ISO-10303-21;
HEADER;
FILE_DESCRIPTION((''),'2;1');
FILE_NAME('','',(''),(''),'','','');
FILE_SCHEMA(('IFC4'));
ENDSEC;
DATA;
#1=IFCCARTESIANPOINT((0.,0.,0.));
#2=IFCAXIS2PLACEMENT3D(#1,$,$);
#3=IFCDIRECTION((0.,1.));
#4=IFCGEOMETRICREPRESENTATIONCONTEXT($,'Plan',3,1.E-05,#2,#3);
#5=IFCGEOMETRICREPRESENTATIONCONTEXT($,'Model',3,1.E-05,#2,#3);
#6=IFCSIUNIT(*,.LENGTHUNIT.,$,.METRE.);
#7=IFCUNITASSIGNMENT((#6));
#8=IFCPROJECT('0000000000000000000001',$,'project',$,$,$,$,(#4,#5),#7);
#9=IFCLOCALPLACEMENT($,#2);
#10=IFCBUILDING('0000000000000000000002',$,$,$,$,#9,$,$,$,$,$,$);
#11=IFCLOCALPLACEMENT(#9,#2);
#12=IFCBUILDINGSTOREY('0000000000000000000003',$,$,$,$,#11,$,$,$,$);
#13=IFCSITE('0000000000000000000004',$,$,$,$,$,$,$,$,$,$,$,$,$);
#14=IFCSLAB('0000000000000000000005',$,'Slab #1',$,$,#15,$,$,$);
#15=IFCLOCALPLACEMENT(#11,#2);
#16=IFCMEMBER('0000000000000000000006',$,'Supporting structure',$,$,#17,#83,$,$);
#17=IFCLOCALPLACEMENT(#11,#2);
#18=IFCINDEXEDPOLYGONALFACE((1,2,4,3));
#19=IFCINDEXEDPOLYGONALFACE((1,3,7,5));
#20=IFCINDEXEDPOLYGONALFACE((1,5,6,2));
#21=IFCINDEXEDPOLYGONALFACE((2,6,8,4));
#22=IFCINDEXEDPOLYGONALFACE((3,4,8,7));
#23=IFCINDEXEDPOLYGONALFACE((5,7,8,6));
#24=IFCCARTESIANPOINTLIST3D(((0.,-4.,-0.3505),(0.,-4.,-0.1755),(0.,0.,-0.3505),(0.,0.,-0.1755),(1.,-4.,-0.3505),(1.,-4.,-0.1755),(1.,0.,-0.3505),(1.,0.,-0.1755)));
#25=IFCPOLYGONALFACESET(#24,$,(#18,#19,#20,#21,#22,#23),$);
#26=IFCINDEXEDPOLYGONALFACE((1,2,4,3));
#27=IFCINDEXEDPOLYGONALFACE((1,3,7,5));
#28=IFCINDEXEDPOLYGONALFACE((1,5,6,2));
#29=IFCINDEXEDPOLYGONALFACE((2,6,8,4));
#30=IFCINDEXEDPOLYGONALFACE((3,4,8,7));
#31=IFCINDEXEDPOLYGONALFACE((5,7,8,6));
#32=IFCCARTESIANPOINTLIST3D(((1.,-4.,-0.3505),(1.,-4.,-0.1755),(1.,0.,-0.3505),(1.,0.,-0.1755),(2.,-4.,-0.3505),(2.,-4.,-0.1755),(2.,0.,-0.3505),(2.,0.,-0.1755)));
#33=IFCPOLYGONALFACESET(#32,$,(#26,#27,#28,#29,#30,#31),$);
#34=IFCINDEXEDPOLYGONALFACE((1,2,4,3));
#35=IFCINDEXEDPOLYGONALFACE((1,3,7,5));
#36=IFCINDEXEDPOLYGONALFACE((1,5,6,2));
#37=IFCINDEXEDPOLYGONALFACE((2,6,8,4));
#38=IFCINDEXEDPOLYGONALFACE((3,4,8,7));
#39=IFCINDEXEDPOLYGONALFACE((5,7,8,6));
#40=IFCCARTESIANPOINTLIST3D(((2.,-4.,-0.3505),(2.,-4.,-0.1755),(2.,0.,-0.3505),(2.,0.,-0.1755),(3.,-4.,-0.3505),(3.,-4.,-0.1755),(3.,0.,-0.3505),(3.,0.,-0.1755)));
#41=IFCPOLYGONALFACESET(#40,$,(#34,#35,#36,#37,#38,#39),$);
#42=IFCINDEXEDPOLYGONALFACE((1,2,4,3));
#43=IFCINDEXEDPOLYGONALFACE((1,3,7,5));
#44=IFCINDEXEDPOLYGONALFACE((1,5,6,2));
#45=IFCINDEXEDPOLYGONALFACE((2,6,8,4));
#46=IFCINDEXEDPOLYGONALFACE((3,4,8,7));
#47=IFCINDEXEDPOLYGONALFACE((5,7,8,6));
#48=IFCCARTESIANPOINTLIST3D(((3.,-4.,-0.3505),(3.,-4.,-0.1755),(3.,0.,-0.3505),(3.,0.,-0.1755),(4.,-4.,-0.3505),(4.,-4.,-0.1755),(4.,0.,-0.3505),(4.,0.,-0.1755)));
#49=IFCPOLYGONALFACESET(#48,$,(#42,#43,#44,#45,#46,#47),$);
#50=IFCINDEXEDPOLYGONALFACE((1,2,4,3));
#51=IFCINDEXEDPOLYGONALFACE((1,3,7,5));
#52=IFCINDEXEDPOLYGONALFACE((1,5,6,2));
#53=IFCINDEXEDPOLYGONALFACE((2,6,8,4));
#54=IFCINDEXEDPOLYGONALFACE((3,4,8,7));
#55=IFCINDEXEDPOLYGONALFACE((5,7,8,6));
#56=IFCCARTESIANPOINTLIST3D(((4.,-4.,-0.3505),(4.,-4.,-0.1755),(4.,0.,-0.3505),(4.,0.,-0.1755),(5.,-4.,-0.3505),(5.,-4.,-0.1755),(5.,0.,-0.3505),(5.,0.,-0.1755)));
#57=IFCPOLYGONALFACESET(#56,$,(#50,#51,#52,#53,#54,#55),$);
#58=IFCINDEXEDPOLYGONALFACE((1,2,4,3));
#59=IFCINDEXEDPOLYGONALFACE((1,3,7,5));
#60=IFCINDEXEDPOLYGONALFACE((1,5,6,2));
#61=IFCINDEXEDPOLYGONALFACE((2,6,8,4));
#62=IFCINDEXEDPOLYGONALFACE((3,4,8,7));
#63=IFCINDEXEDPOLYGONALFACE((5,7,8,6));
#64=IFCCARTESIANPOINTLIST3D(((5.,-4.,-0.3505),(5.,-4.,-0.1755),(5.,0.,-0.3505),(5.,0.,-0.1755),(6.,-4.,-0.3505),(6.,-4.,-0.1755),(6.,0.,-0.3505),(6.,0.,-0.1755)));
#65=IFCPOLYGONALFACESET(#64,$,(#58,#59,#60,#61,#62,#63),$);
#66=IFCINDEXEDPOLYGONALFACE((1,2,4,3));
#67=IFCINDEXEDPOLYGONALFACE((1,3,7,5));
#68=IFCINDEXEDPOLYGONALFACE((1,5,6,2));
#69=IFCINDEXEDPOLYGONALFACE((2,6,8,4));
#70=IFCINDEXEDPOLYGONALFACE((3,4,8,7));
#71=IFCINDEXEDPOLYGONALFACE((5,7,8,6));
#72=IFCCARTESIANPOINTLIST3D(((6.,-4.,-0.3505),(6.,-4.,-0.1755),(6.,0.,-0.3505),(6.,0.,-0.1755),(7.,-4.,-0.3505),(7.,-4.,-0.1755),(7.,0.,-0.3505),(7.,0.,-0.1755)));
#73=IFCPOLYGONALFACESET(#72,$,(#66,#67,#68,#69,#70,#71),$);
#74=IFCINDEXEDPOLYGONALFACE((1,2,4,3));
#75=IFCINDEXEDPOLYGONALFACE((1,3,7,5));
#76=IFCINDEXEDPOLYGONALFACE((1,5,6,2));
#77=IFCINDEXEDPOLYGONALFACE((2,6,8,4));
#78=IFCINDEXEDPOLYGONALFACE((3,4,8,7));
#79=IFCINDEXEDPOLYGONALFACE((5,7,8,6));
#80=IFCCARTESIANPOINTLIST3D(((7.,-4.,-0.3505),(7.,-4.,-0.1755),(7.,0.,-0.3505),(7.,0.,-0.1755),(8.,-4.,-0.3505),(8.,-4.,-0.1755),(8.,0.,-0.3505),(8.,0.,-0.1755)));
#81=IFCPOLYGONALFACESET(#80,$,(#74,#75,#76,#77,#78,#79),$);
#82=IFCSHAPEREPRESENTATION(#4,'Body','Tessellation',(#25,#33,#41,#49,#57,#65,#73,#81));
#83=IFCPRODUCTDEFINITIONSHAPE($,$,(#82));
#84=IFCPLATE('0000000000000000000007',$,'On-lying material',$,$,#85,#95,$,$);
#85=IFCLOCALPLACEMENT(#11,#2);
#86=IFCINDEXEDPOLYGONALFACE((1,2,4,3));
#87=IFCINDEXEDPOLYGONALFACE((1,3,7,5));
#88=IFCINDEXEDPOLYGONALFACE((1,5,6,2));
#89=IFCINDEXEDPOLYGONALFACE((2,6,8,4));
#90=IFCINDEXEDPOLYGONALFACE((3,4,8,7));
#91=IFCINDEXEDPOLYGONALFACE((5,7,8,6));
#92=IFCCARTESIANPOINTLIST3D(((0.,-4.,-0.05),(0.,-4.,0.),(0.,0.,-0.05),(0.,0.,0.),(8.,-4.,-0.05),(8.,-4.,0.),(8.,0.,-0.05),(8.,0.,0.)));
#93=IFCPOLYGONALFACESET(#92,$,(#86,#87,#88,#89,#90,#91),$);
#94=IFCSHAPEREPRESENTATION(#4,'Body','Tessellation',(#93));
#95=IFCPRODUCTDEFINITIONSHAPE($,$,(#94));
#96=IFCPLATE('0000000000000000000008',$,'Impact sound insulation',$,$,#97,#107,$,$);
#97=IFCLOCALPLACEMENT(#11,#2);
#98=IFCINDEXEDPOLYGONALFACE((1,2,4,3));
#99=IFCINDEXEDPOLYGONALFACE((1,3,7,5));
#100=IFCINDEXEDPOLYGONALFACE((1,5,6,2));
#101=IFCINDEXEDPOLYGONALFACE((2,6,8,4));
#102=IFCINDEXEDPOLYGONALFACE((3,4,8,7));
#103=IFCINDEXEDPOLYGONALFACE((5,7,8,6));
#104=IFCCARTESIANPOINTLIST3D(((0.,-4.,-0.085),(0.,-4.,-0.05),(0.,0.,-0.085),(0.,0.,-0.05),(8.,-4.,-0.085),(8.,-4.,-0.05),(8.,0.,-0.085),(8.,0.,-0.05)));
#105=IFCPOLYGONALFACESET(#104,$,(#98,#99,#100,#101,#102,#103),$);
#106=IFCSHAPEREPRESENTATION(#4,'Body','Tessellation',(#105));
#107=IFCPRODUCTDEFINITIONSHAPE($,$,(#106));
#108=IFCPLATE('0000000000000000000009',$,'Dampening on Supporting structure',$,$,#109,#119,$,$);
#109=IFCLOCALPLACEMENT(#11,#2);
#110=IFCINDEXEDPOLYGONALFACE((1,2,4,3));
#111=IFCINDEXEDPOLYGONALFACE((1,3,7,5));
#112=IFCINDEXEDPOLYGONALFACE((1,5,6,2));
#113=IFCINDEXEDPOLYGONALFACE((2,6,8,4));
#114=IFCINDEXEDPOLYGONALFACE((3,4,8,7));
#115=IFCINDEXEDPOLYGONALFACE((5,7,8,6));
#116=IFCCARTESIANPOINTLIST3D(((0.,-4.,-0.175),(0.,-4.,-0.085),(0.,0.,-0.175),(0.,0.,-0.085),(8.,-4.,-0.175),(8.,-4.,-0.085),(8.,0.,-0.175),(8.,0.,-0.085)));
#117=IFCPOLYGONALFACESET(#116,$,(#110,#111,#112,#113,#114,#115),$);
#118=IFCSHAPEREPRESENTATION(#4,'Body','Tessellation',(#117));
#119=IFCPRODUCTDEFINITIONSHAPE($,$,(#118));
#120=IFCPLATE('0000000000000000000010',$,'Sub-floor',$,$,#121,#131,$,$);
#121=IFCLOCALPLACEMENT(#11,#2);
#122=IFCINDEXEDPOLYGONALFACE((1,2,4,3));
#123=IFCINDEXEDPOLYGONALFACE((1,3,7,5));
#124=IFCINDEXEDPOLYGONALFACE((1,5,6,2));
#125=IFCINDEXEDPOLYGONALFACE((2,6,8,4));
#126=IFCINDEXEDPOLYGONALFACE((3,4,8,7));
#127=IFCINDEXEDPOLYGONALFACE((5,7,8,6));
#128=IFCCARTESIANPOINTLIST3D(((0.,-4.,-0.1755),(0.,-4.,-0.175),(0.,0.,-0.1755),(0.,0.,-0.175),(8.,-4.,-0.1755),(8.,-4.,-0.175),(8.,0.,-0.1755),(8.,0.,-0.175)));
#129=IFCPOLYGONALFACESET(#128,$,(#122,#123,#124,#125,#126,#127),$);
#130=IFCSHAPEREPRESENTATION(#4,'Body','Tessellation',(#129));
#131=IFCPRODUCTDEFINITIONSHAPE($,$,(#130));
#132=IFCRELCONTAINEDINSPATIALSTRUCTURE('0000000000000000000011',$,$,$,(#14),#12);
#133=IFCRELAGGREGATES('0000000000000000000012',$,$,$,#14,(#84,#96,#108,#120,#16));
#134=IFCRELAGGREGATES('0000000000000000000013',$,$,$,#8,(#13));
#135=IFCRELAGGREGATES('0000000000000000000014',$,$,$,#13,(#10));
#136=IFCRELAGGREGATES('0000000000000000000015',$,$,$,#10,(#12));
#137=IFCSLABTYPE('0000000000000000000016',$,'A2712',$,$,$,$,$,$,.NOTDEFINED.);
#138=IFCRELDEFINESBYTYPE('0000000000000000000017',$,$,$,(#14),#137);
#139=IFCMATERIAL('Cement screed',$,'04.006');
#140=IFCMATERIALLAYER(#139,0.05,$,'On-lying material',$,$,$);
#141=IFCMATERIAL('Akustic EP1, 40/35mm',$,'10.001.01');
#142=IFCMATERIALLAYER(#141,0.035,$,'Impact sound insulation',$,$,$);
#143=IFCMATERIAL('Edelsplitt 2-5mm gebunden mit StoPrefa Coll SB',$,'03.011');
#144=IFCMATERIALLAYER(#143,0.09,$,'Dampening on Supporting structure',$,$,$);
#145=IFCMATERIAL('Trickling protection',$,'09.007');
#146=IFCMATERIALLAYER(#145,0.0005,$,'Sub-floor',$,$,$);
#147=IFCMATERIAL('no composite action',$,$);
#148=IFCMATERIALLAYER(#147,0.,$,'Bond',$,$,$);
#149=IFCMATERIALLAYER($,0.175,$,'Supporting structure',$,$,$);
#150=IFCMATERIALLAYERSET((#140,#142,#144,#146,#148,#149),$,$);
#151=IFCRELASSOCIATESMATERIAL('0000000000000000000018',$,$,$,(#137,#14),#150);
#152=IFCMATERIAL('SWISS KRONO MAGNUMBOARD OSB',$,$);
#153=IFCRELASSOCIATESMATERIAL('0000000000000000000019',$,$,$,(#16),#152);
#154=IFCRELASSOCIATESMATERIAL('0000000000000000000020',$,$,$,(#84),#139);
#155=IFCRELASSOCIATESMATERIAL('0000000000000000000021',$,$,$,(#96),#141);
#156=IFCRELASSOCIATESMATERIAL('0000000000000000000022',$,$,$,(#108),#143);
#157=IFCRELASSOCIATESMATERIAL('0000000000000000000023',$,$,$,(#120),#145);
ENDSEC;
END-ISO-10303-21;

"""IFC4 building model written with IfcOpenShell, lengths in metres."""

from ifc_helpers import new_model, si_unit, direction, frame, frame_2d, origin, origin_with_axes, place, context, project, spatial, rectangle, extrude, material, layer, layer_set, type_object, element, aggregate, save


model = new_model("IFC4")

# Units and contexts
plan_context = context("Plan", 3, precision=1e-05, world=origin(), true_north=direction((0.0, 1.0)))
model_context = context("Model", 3, precision=1e-05, world=origin(), true_north=direction((0.0, 1.0)))
ifc_project = project(units=[si_unit("LENGTHUNIT", "METRE")], contexts=[plan_context, model_context])

# Site, building, storey
site = spatial("IfcSite", under=ifc_project)
building_placement = place(None, origin())
building = spatial("IfcBuilding", under=site, at=building_placement)
storey_placement = place(building_placement, origin())
storey = spatial("IfcBuildingStorey", under=building, at=storey_placement)

# Slab, member, plates
ifc_material_1 = material(Name="Cement screed", Category="04.006")
ifc_layer_1 = layer(ifc_material_1, 0.05, Name="On-lying material")
ifc_material_2 = material(Name="Akustic EP1, 40/35mm", Category="10.001.01")
ifc_layer_2 = layer(ifc_material_2, 0.035, Name="Impact sound insulation")
ifc_material_3 = material(Name="Edelsplitt 2-5mm gebunden mit StoPrefa Coll SB", Category="03.011")
ifc_layer_3 = layer(ifc_material_3, 0.09, Name="Dampening on Supporting structure")
ifc_material_4 = material(Name="Trickling protection", Category="09.007")
ifc_layer_4 = layer(ifc_material_4, 0.0005, Name="Sub-floor")
ifc_material_5 = material(Name="no composite action")
ifc_layer_5 = layer(ifc_material_5, 0.0, Name="Bond")
ifc_layer_6 = layer(None, 0.175, Name="Supporting structure")
ifc_layer_set = layer_set([ifc_layer_1, ifc_layer_2, ifc_layer_3, ifc_layer_4, ifc_layer_5, ifc_layer_6])
slab_type = type_object("IfcSlabType", Name="A2712", PredefinedType="NOTDEFINED", material=ifc_layer_set)
slab_placement = place(None, frame((0.0, 0.0, 0.0), z_axis=(0.0, 0.0, -1.0), x_axis=(1.0, 0.0, 0.0)))
slab = element("IfcSlab", 1, at=slab_placement, inside=storey, type_object=slab_type, material=ifc_layer_set, Name="Slab #1")
ifc_material_6 = material(Name="SWISS KRONO MAGNUMBOARD OSB")
member_placement = place(slab_placement, origin())
member = element("IfcMember", 2, at=member_placement, material=ifc_material_6, Name="Supporting structure", context=plan_context, shape_type="SweptSolid", body=[
    extrude(rectangle(XDim=1.0, YDim=0.175, at=frame_2d((0.5, 0.0875), x_axis=(1.0, 0.0))), frame((0.0, 4.0, 0.1755), z_axis=(0.0, -1.0, 0.0), x_axis=(1.0, 0.0, 0.0)), (0.0, 0.0, 1.0), 4.0),
    extrude(rectangle(XDim=1.0, YDim=0.175, at=frame_2d((0.5, 0.0875), x_axis=(1.0, 0.0))), frame((1.0, 4.0, 0.1755), z_axis=(0.0, -1.0, 0.0), x_axis=(1.0, 0.0, 0.0)), (0.0, 0.0, 1.0), 4.0),
    extrude(rectangle(XDim=1.0, YDim=0.175, at=frame_2d((0.5, 0.0875), x_axis=(1.0, 0.0))), frame((2.0, 4.0, 0.1755), z_axis=(0.0, -1.0, 0.0), x_axis=(1.0, 0.0, 0.0)), (0.0, 0.0, 1.0), 4.0),
    extrude(rectangle(XDim=1.0, YDim=0.175, at=frame_2d((0.5, 0.0875), x_axis=(1.0, 0.0))), frame((3.0, 4.0, 0.1755), z_axis=(0.0, -1.0, 0.0), x_axis=(1.0, 0.0, 0.0)), (0.0, 0.0, 1.0), 4.0),
    extrude(rectangle(XDim=1.0, YDim=0.175, at=frame_2d((0.5, 0.0875), x_axis=(1.0, 0.0))), frame((4.0, 4.0, 0.1755), z_axis=(0.0, -1.0, 0.0), x_axis=(1.0, 0.0, 0.0)), (0.0, 0.0, 1.0), 4.0),
    extrude(rectangle(XDim=1.0, YDim=0.175, at=frame_2d((0.5, 0.0875), x_axis=(1.0, 0.0))), frame((5.0, 4.0, 0.1755), z_axis=(0.0, -1.0, 0.0), x_axis=(1.0, 0.0, 0.0)), (0.0, 0.0, 1.0), 4.0),
    extrude(rectangle(XDim=1.0, YDim=0.175, at=frame_2d((0.5, 0.0875), x_axis=(1.0, 0.0))), frame((6.0, 4.0, 0.1755), z_axis=(0.0, -1.0, 0.0), x_axis=(1.0, 0.0, 0.0)), (0.0, 0.0, 1.0), 4.0),
    extrude(rectangle(XDim=1.0, YDim=0.175, at=frame_2d((0.5, 0.0875), x_axis=(1.0, 0.0))), frame((7.0, 4.0, 0.1755), z_axis=(0.0, -1.0, 0.0), x_axis=(1.0, 0.0, 0.0)), (0.0, 0.0, 1.0), 4.0),
])
plate_1_placement = place(slab_placement, origin())
plate_1 = element("IfcPlate", 3, at=plate_1_placement, material=ifc_material_1, Name="On-lying material", context=plan_context, shape_type="SweptSolid", body=[
    extrude(rectangle(XDim=8.0, YDim=4.0, at=frame_2d((4.0, 2.0), x_axis=(1.0, 0.0))), origin_with_axes(), (0.0, 0.0, 1.0), 0.05),
])
plate_2_placement = place(slab_placement, origin())
plate_2 = element("IfcPlate", 4, at=plate_2_placement, material=ifc_material_2, Name="Impact sound insulation", context=plan_context, shape_type="SweptSolid", body=[
    extrude(rectangle(XDim=8.0, YDim=4.0, at=frame_2d((4.0, 2.0), x_axis=(1.0, 0.0))), frame((0.0, 0.0, 0.05), z_axis=(0.0, 0.0, 1.0), x_axis=(1.0, 0.0, 0.0)), (0.0, 0.0, 1.0), 0.035),
])
plate_3_placement = place(slab_placement, origin())
plate_3 = element("IfcPlate", 5, at=plate_3_placement, material=ifc_material_3, Name="Dampening on Supporting structure", context=plan_context, shape_type="SweptSolid", body=[
    extrude(rectangle(XDim=8.0, YDim=4.0, at=frame_2d((4.0, 2.0), x_axis=(1.0, 0.0))), frame((0.0, 0.0, 0.085), z_axis=(0.0, 0.0, 1.0), x_axis=(1.0, 0.0, 0.0)), (0.0, 0.0, 1.0), 0.09),
])
plate_4_placement = place(slab_placement, origin())
plate_4 = element("IfcPlate", 6, at=plate_4_placement, material=ifc_material_4, Name="Sub-floor", context=plan_context, shape_type="SweptSolid", body=[
    extrude(rectangle(XDim=8.0, YDim=4.0, at=frame_2d((4.0, 2.0), x_axis=(1.0, 0.0))), frame((0.0, 0.0, 0.175), z_axis=(0.0, 0.0, 1.0), x_axis=(1.0, 0.0, 0.0)), (0.0, 0.0, 1.0), 0.0005),
])
aggregate(slab, [plate_1, plate_2, plate_3, plate_4, member])

save(model, "model.ifc")
